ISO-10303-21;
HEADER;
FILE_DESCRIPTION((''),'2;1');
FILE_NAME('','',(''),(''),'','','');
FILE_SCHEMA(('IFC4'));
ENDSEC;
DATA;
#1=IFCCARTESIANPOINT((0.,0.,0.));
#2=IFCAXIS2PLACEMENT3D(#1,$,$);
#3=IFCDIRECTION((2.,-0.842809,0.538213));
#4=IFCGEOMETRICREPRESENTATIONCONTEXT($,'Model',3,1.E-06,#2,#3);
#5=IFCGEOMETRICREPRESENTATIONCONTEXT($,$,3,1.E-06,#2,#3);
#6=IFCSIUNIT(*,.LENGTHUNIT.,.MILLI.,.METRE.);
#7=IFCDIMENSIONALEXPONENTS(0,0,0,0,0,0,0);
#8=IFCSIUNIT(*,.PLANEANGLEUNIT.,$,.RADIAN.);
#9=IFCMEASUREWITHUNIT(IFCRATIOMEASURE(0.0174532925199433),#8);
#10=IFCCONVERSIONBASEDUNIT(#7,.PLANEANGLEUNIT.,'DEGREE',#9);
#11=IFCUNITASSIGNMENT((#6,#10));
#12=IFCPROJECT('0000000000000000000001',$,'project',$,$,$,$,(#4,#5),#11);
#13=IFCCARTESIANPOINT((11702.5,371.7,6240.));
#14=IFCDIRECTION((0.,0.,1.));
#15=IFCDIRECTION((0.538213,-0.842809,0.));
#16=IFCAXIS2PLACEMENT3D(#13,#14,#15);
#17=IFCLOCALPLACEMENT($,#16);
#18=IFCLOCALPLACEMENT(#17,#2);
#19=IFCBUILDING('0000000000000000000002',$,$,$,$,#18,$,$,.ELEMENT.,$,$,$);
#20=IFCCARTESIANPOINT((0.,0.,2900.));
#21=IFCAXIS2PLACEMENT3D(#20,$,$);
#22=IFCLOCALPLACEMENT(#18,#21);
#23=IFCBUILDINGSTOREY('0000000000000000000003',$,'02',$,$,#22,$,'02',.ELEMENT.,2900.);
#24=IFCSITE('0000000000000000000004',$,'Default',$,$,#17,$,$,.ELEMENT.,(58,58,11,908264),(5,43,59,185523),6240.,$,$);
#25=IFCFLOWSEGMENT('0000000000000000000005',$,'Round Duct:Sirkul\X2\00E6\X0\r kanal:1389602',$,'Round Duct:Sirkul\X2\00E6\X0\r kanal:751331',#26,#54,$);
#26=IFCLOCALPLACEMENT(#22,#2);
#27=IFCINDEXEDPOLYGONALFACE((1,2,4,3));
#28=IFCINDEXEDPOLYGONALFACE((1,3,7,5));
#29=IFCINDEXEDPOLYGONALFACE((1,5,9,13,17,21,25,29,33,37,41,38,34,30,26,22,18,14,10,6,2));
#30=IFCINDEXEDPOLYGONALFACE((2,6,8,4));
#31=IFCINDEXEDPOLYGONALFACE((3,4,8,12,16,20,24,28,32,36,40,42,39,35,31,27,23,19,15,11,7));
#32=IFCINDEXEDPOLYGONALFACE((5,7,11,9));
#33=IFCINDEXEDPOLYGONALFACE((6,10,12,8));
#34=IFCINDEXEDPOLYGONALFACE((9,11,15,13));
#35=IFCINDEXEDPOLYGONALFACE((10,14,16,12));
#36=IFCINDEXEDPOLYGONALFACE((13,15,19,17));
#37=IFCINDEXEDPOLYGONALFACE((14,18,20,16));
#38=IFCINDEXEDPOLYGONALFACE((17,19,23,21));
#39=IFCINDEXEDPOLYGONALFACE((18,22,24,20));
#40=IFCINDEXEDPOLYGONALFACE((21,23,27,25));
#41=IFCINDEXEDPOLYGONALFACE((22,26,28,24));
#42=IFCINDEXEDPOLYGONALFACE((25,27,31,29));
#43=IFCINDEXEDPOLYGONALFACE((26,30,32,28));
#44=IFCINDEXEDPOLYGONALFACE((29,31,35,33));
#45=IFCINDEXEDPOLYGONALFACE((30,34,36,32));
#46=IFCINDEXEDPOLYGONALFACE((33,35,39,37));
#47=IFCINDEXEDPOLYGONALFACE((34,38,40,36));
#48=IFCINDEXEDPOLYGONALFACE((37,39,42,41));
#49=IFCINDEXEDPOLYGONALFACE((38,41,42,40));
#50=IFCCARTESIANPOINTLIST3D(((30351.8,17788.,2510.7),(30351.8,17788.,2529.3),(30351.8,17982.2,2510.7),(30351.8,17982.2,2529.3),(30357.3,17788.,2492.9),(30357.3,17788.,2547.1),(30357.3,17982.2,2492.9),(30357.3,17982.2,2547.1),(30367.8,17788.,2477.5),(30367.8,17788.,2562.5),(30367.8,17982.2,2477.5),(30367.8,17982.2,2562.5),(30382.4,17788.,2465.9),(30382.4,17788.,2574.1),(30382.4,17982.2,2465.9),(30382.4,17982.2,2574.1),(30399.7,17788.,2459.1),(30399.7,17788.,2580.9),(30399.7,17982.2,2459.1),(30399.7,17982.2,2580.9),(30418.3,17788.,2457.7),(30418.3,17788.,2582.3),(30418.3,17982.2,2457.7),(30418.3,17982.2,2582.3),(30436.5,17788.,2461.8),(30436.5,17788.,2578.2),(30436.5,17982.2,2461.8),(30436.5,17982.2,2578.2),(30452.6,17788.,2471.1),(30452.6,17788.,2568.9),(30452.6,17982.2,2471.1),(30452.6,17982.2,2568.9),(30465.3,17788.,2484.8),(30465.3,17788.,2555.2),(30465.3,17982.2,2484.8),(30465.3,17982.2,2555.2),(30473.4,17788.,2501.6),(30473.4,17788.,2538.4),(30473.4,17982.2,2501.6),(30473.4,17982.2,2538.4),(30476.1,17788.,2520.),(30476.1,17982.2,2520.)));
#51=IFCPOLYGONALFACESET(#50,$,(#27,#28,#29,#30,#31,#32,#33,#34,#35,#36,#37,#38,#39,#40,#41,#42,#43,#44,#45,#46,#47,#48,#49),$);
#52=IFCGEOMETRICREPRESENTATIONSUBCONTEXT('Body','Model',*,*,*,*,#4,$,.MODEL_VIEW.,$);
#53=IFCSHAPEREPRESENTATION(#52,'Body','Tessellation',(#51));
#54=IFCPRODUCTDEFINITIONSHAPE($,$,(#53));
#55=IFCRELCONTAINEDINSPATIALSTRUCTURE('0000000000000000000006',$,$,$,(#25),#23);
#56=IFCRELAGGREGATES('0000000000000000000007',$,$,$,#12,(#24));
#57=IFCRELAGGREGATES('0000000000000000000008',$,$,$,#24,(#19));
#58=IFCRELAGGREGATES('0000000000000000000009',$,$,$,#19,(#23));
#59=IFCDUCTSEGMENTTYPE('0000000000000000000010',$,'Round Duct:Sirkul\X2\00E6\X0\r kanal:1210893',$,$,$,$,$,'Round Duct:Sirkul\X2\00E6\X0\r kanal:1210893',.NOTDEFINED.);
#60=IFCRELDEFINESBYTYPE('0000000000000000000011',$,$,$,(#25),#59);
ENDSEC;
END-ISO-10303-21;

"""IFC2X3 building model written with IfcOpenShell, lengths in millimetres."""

from ifc_helpers import new_model, entity, si_unit, converted_unit, direction, frame, origin, origin_2d_with_axis, place, context, subcontext, project, spatial, circle, extrude, type_object, element, save


model = new_model("IFC2X3")

# Units and contexts
model_context = context("Model", 3, precision=1e-06, world=origin(), true_north=direction((2.0, -0.842809, 0.538213)))
context_of_model = context(None, 3, precision=1e-06, world=origin(), true_north=direction((2.0, -0.842809, 0.538213)))
body_context = subcontext(model_context, "Body", "Model", "MODEL_VIEW")
ifc_project = project(units=[si_unit("LENGTHUNIT", "METRE", prefix="MILLI"), converted_unit("PLANEANGLEUNIT", "DEGREE", entity("IfcRatioMeasure", 0.0174532925199433), si_unit("PLANEANGLEUNIT", "RADIAN"), dimensions=[0, 0, 0, 0, 0, 0, 0])], contexts=[model_context, context_of_model])

# Site, building, storey
site_placement = place(None, frame((11702.5, 371.7, 6240.0), z_axis=(0.0, 0.0, 1.0), x_axis=(0.538213, -0.842809, 0.0)))
site = spatial("IfcSite", under=ifc_project, at=site_placement, Name="Default", CompositionType="ELEMENT", RefLatitude=(58, 58, 11, 908264), RefLongitude=(5, 43, 59, 185523), RefElevation=6240.0)
building_placement = place(site_placement, origin())
building = spatial("IfcBuilding", under=site, at=building_placement, CompositionType="ELEMENT")
storey_placement = place(building_placement, frame((0.0, 0.0, 2900.0)))
storey = spatial("IfcBuildingStorey", under=building, at=storey_placement, Name="02", LongName="02", CompositionType="ELEMENT", Elevation=2900.0)

# Flow segment
duct_segment_type = type_object("IfcDuctSegmentType", Name="Round Duct:Sirkulær kanal:1210893", ElementType="Round Duct:Sirkulær kanal:1210893", PredefinedType="NOTDEFINED")
flow_segment_1_placement = place(storey_placement, origin())
element("IfcFlowSegment", 1, at=flow_segment_1_placement, inside=storey, type_object=duct_segment_type, Name="Round Duct:Sirkulær kanal:1389602", ObjectType="Round Duct:Sirkulær kanal:751331", context=body_context, shape_type="SweptSolid", body=[
    extrude(circle(Radius=62.5, at=origin_2d_with_axis()), frame((30413.6, 17788.0, 2520.0), z_axis=(0.000053, 1.0, 0.0), x_axis=(1.0, -0.000053, 0.0)), (0.0, 0.0, 1.0), 194.2),
])

save(model, "model.ifc")
